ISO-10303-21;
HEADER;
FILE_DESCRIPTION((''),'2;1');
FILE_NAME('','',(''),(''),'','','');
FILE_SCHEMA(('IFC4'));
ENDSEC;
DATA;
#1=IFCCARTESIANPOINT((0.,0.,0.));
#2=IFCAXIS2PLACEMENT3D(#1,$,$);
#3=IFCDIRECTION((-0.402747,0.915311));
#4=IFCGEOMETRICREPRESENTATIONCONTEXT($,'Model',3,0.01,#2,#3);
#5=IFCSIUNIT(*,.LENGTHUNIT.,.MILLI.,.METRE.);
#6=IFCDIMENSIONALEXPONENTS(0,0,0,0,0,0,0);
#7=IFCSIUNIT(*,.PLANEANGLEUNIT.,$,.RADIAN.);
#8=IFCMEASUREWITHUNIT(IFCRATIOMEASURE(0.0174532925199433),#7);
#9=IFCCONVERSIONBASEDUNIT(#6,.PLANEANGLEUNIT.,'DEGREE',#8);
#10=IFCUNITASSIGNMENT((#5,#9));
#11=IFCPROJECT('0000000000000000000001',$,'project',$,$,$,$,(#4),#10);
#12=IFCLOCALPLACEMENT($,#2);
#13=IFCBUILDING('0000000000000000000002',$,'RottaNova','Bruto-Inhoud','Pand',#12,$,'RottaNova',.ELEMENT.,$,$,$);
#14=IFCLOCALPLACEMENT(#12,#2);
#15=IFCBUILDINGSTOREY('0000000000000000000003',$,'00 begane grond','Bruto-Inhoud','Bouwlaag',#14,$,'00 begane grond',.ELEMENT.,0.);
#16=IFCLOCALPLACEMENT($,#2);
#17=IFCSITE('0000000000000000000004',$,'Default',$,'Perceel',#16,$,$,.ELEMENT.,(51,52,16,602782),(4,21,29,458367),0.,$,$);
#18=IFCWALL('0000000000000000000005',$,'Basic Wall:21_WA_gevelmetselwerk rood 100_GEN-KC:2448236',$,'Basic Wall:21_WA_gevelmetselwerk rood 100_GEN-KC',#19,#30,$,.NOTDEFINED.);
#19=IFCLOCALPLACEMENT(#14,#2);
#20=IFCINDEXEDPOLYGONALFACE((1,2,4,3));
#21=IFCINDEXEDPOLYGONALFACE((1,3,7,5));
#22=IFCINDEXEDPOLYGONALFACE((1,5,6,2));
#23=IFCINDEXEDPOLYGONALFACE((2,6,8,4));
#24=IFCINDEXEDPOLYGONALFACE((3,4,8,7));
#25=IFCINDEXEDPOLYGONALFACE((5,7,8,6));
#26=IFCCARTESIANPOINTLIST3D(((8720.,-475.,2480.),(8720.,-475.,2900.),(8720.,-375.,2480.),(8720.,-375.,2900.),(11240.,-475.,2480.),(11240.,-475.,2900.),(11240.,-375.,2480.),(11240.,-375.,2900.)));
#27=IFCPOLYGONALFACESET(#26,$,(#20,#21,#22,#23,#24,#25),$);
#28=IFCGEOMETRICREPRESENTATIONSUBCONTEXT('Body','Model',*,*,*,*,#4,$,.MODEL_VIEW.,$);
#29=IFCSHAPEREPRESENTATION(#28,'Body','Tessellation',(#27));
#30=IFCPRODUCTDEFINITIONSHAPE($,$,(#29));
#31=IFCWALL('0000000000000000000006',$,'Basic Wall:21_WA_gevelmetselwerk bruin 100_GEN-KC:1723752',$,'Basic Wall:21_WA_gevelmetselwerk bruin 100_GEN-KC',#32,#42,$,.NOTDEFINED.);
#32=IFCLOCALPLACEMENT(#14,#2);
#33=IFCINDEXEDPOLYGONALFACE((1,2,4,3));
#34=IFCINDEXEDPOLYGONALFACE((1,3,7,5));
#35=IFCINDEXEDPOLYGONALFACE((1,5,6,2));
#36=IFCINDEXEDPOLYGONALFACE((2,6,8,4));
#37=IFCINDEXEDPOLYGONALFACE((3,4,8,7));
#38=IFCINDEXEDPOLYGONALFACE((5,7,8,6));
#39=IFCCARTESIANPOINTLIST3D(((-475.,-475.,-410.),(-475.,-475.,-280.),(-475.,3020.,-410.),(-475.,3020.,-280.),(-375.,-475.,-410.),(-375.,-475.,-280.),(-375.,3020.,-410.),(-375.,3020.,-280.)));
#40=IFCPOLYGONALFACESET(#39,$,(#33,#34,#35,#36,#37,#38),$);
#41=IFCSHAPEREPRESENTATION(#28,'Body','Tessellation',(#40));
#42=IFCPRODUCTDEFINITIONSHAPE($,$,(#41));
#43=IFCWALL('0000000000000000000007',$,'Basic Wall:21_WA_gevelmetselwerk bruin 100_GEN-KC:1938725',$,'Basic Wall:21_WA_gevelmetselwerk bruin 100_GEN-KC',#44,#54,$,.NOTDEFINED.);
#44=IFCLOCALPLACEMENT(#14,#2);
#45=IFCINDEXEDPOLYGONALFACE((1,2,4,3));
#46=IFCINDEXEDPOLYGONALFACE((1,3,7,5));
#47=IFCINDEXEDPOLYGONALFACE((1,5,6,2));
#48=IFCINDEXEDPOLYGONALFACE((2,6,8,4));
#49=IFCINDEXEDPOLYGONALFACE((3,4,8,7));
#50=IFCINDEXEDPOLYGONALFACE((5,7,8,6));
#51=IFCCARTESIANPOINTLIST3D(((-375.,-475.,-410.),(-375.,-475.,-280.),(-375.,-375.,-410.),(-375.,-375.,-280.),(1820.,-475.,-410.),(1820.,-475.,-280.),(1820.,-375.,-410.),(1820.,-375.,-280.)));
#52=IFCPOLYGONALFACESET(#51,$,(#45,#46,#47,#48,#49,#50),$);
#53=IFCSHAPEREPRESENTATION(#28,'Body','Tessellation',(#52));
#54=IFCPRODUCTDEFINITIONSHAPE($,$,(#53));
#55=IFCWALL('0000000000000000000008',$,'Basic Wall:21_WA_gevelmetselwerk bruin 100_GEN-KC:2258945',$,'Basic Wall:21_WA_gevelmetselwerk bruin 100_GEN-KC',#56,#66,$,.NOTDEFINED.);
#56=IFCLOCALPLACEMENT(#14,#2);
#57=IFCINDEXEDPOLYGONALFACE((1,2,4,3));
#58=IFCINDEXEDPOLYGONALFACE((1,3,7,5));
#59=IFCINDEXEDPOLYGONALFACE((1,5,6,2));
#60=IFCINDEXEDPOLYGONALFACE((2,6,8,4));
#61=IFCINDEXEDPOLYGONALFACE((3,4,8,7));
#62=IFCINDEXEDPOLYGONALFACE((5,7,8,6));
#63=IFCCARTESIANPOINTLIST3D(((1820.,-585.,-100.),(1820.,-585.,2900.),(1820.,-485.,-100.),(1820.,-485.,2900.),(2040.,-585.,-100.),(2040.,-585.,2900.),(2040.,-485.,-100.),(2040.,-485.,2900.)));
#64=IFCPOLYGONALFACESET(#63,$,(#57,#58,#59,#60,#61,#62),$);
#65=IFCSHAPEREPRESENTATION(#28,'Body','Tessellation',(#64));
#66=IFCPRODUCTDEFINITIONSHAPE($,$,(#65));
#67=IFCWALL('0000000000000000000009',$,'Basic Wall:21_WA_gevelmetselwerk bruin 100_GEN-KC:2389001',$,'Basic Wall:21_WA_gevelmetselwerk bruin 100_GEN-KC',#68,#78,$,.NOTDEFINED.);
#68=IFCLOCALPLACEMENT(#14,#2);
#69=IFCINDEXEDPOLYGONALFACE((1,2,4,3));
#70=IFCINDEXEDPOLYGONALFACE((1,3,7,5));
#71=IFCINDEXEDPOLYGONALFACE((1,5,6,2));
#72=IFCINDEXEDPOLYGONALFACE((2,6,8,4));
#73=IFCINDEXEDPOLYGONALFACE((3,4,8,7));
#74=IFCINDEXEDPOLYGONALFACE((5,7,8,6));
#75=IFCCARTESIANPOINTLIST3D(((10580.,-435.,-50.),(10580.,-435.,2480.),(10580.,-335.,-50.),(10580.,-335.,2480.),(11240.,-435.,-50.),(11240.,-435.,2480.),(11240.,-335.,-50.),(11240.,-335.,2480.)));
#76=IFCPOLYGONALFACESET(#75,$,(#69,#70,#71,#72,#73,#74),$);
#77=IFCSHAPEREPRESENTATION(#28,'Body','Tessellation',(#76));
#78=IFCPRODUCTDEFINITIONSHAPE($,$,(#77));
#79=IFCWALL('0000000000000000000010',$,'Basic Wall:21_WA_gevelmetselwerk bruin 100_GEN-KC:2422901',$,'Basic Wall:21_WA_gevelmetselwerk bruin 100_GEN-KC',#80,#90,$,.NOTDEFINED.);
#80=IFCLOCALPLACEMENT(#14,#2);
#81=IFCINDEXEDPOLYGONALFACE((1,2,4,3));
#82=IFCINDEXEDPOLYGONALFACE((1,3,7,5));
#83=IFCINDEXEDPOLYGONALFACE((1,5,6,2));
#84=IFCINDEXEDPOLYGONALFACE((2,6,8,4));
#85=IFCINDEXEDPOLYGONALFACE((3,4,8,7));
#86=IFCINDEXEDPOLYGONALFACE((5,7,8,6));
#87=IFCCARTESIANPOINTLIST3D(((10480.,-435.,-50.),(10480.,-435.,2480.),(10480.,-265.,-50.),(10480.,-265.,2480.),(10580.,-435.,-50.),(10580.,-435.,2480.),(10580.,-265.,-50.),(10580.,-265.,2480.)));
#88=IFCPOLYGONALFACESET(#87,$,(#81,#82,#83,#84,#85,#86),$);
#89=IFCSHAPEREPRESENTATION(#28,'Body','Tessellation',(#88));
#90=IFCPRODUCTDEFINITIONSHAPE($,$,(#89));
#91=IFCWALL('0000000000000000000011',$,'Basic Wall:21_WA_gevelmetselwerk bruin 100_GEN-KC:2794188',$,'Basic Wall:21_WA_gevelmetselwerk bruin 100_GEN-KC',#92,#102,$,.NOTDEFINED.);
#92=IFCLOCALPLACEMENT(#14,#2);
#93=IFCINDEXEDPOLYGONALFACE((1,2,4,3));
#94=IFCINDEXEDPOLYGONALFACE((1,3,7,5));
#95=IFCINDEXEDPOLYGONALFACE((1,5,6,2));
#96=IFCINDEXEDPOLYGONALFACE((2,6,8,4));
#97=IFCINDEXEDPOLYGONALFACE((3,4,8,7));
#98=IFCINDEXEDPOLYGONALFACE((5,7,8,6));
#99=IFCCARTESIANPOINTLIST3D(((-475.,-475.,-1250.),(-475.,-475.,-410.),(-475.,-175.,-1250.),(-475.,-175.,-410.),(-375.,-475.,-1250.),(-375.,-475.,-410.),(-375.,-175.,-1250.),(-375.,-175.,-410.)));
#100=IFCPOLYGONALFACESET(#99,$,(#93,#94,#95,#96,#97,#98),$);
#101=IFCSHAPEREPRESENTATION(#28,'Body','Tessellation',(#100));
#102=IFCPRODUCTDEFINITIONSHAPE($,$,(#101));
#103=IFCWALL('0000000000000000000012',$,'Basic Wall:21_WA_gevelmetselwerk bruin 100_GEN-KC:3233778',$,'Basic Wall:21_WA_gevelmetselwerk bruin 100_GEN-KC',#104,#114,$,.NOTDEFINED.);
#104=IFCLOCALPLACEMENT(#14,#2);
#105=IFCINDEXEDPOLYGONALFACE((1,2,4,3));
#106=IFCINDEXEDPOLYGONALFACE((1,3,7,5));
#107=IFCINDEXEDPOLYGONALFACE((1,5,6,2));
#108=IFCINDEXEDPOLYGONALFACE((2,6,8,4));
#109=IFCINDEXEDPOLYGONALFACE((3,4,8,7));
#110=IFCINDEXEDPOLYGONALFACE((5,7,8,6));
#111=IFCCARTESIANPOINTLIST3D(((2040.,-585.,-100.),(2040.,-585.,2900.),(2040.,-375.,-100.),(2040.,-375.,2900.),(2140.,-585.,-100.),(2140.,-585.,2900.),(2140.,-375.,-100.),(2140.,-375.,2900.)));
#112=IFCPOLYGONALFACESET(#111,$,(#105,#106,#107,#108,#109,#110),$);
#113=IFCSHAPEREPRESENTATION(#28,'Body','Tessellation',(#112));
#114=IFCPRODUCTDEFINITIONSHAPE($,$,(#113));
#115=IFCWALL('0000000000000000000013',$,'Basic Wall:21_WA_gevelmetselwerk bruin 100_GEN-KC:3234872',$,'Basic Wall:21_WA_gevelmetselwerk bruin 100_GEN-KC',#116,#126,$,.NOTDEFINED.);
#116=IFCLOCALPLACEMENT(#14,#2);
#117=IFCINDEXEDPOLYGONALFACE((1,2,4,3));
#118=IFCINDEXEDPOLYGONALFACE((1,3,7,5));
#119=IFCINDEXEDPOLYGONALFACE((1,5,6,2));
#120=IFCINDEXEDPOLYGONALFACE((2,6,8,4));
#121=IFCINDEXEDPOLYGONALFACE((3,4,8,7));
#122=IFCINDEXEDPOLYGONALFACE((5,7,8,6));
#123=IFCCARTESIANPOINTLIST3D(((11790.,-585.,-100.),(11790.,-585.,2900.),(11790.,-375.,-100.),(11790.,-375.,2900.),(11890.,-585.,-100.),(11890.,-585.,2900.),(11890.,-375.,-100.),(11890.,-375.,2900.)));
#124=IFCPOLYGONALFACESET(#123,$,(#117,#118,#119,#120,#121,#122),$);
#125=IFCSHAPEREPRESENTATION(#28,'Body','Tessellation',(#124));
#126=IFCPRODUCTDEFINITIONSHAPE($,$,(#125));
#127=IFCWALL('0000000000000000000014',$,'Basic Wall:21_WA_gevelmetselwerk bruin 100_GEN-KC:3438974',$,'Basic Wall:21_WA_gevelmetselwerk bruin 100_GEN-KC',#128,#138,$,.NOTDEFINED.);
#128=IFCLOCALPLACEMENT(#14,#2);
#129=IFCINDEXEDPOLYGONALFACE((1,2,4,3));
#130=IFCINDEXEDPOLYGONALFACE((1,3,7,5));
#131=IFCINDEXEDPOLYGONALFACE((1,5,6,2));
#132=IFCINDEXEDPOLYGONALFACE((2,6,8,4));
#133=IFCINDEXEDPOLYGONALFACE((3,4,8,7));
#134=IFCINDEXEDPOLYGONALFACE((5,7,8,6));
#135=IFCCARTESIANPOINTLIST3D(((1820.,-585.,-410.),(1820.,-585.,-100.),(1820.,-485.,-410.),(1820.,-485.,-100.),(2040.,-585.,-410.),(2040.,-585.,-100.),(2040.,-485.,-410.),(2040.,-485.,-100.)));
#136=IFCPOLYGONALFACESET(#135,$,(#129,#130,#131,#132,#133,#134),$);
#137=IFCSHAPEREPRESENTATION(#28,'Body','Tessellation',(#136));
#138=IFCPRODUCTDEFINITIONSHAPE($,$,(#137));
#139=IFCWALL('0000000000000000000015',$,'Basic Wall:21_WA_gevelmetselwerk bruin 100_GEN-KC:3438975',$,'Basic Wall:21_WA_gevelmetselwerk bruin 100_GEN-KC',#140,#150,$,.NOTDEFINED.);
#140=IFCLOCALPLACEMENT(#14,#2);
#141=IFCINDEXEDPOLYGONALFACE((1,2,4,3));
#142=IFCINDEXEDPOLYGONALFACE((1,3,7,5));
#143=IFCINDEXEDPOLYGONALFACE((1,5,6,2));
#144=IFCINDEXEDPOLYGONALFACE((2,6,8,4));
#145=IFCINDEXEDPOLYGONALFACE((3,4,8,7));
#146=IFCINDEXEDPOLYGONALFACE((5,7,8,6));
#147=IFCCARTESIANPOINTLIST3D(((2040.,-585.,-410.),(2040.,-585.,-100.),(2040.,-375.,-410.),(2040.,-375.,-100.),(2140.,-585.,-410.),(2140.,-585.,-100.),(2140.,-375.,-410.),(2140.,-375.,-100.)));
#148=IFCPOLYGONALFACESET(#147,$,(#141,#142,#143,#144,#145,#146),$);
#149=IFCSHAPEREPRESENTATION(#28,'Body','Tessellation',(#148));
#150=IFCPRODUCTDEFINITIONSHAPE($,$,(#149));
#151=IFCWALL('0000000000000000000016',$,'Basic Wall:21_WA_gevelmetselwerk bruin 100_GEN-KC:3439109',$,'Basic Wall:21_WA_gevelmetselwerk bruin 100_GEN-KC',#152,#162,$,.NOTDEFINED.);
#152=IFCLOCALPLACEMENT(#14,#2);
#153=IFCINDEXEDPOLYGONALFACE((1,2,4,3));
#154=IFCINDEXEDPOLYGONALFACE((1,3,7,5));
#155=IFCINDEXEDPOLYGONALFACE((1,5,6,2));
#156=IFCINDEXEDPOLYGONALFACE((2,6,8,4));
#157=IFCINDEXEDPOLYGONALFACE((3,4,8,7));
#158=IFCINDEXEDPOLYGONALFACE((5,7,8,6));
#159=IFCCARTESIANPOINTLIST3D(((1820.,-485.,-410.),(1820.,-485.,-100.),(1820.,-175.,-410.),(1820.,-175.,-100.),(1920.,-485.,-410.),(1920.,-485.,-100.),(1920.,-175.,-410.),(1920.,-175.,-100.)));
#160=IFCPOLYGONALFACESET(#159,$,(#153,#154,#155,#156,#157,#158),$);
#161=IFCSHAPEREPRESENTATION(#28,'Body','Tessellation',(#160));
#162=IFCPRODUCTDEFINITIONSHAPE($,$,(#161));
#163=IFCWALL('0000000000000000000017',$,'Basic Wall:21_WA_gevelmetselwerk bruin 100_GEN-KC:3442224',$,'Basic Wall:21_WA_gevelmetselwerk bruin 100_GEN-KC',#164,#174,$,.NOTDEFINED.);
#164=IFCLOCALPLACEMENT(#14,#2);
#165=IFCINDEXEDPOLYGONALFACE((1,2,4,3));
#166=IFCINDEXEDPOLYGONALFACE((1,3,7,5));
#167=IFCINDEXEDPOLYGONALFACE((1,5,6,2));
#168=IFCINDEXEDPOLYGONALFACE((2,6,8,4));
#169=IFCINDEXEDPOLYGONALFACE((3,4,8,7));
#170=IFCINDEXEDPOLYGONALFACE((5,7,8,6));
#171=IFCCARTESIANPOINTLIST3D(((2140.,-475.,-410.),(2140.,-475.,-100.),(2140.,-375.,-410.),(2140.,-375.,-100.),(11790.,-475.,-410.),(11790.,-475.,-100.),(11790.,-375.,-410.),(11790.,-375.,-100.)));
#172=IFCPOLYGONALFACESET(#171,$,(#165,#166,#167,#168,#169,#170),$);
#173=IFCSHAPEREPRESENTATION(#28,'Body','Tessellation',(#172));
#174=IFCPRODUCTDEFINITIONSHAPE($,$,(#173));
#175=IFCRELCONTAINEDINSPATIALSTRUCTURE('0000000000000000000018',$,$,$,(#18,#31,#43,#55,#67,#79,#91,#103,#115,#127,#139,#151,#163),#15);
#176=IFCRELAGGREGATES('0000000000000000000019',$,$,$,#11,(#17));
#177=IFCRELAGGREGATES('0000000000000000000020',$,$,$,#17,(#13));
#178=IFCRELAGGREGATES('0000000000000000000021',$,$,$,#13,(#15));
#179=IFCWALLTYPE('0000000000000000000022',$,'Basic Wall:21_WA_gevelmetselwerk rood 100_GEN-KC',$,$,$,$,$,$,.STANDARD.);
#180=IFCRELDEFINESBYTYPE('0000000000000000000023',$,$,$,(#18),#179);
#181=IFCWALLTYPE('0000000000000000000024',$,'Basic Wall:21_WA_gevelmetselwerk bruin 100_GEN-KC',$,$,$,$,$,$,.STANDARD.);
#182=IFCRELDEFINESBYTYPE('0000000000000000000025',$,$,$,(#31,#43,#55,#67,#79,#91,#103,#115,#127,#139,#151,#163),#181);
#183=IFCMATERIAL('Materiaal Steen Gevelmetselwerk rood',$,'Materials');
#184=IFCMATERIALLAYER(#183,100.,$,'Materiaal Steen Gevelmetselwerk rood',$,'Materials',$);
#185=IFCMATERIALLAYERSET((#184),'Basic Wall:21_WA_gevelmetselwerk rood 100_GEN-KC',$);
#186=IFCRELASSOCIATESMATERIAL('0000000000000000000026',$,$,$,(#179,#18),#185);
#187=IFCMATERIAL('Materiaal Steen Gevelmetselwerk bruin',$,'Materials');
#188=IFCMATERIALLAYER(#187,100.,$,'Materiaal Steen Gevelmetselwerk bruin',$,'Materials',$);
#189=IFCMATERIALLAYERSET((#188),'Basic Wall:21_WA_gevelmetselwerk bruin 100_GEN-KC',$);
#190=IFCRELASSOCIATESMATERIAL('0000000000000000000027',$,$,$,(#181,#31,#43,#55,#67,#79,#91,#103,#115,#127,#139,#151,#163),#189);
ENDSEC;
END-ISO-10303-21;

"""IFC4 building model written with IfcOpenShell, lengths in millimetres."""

from ifc_helpers import new_model, entity, si_unit, converted_unit, direction, frame, frame_2d, origin, place, context, subcontext, project, spatial, rectangle, extrude, material, layer, layer_set, type_object, element, save


model = new_model("IFC4")

# Units and contexts
model_context = context("Model", 3, precision=0.01, world=origin(), true_north=direction((-0.402747, 0.915311)))
body_context = subcontext(model_context, "Body", "Model", "MODEL_VIEW")
ifc_project = project(units=[si_unit("LENGTHUNIT", "METRE", prefix="MILLI"), converted_unit("PLANEANGLEUNIT", "DEGREE", entity("IfcRatioMeasure", 0.0174532925199433), si_unit("PLANEANGLEUNIT", "RADIAN"), dimensions=[0, 0, 0, 0, 0, 0, 0])], contexts=[model_context])

# Site, building, storey
site_placement = place(None, origin())
site = spatial("IfcSite", under=ifc_project, at=site_placement, Name="Default", ObjectType="Perceel", CompositionType="ELEMENT", RefLatitude=(51, 52, 16, 602782), RefLongitude=(4, 21, 29, 458367), RefElevation=0.0)
building_placement = place(None, origin())
building = spatial("IfcBuilding", under=site, at=building_placement, Name="RottaNova", Description="Bruto-Inhoud", ObjectType="Pand", LongName="RottaNova", CompositionType="ELEMENT")
storey_placement = place(building_placement, origin())
storey = spatial("IfcBuildingStorey", under=building, at=storey_placement, Name="00 begane grond", Description="Bruto-Inhoud", ObjectType="Bouwlaag", LongName="00 begane grond", CompositionType="ELEMENT", Elevation=0.0)

# Walls
ifc_material_1 = material(Name="Materiaal Steen Gevelmetselwerk rood", Category="Materials")
ifc_layer_1 = layer(ifc_material_1, 100.0, Name="Materiaal Steen Gevelmetselwerk rood", Category="Materials")
ifc_layer_set_1 = layer_set([ifc_layer_1], Name="Basic Wall:21_WA_gevelmetselwerk rood 100_GEN-KC")
wall_type_1 = type_object("IfcWallType", Name="Basic Wall:21_WA_gevelmetselwerk rood 100_GEN-KC", PredefinedType="STANDARD", material=ifc_layer_set_1)
wall_1_placement = place(storey_placement, frame((8720.0, -425.0, 2480.0)))
element("IfcWall", 1, at=wall_1_placement, inside=storey, type_object=wall_type_1, material=ifc_layer_set_1, Name="Basic Wall:21_WA_gevelmetselwerk rood 100_GEN-KC:2448236", ObjectType="Basic Wall:21_WA_gevelmetselwerk rood 100_GEN-KC", PredefinedType="NOTDEFINED", context=body_context, shape_type="SweptSolid", body=[
    extrude(rectangle(XDim=2520.0, YDim=100.0, at=frame_2d((1260.0, 0.0), x_axis=(-1.0, 0.0))), origin(), (0.0, 0.0, 1.0), 420.0),
])
ifc_material_2 = material(Name="Materiaal Steen Gevelmetselwerk bruin", Category="Materials")
ifc_layer_2 = layer(ifc_material_2, 100.0, Name="Materiaal Steen Gevelmetselwerk bruin", Category="Materials")
ifc_layer_set_2 = layer_set([ifc_layer_2], Name="Basic Wall:21_WA_gevelmetselwerk bruin 100_GEN-KC")
wall_type_2 = type_object("IfcWallType", Name="Basic Wall:21_WA_gevelmetselwerk bruin 100_GEN-KC", PredefinedType="STANDARD", material=ifc_layer_set_2)
wall_2_placement = place(storey_placement, frame((-425.0, -475.0, -410.0), z_axis=(0.0, 0.0, 1.0), x_axis=(0.0, 1.0, 0.0)))
element("IfcWall", 2, at=wall_2_placement, inside=storey, type_object=wall_type_2, material=ifc_layer_set_2, Name="Basic Wall:21_WA_gevelmetselwerk bruin 100_GEN-KC:1723752", ObjectType="Basic Wall:21_WA_gevelmetselwerk bruin 100_GEN-KC", PredefinedType="NOTDEFINED", context=body_context, shape_type="SweptSolid", body=[
    extrude(rectangle(XDim=3495.0, YDim=100.0, at=frame_2d((1747.5, 0.0), x_axis=(-1.0, 0.0))), origin(), (0.0, 0.0, 1.0), 130.0),
])
wall_3_placement = place(storey_placement, frame((1820.0, -425.0, -410.0), z_axis=(0.0, 0.0, 1.0), x_axis=(-1.0, 0.0, 0.0)))
element("IfcWall", 3, at=wall_3_placement, inside=storey, type_object=wall_type_2, material=ifc_layer_set_2, Name="Basic Wall:21_WA_gevelmetselwerk bruin 100_GEN-KC:1938725", ObjectType="Basic Wall:21_WA_gevelmetselwerk bruin 100_GEN-KC", PredefinedType="NOTDEFINED", context=body_context, shape_type="SweptSolid", body=[
    extrude(rectangle(XDim=2195.0, YDim=100.0, at=frame_2d((1097.5, 0.0), x_axis=(-1.0, 0.0))), origin(), (0.0, 0.0, 1.0), 130.0),
])
wall_4_placement = place(storey_placement, frame((1820.0, -535.0, -100.0)))
element("IfcWall", 4, at=wall_4_placement, inside=storey, type_object=wall_type_2, material=ifc_layer_set_2, Name="Basic Wall:21_WA_gevelmetselwerk bruin 100_GEN-KC:2258945", ObjectType="Basic Wall:21_WA_gevelmetselwerk bruin 100_GEN-KC", PredefinedType="NOTDEFINED", context=body_context, shape_type="SweptSolid", body=[
    extrude(rectangle(XDim=220.0, YDim=100.0, at=frame_2d((110.0, 0.0), x_axis=(-1.0, 0.0))), origin(), (0.0, 0.0, 1.0), 3000.0),
])
wall_5_placement = place(storey_placement, frame((11240.0, -385.0, -50.0), z_axis=(0.0, 0.0, 1.0), x_axis=(-1.0, 0.0, 0.0)))
element("IfcWall", 5, at=wall_5_placement, inside=storey, type_object=wall_type_2, material=ifc_layer_set_2, Name="Basic Wall:21_WA_gevelmetselwerk bruin 100_GEN-KC:2389001", ObjectType="Basic Wall:21_WA_gevelmetselwerk bruin 100_GEN-KC", PredefinedType="NOTDEFINED", context=body_context, shape_type="SweptSolid", body=[
    extrude(rectangle(XDim=660.0, YDim=100.0, at=frame_2d((330.0, 0.0), x_axis=(-1.0, 0.0))), origin(), (0.0, 0.0, 1.0), 2530.0),
])
wall_6_placement = place(storey_placement, frame((10530.0, -265.0, -50.0), z_axis=(0.0, 0.0, 1.0), x_axis=(0.0, -1.0, 0.0)))
element("IfcWall", 6, at=wall_6_placement, inside=storey, type_object=wall_type_2, material=ifc_layer_set_2, Name="Basic Wall:21_WA_gevelmetselwerk bruin 100_GEN-KC:2422901", ObjectType="Basic Wall:21_WA_gevelmetselwerk bruin 100_GEN-KC", PredefinedType="NOTDEFINED", context=body_context, shape_type="SweptSolid", body=[
    extrude(rectangle(XDim=170.0, YDim=100.0, at=frame_2d((85.0, 0.0), x_axis=(-1.0, 0.0))), origin(), (0.0, 0.0, 1.0), 2530.0),
])
wall_7_placement = place(storey_placement, frame((-425.0, -475.0, -1250.0), z_axis=(0.0, 0.0, 1.0), x_axis=(0.0, 1.0, 0.0)))
element("IfcWall", 7, at=wall_7_placement, inside=storey, type_object=wall_type_2, material=ifc_layer_set_2, Name="Basic Wall:21_WA_gevelmetselwerk bruin 100_GEN-KC:2794188", ObjectType="Basic Wall:21_WA_gevelmetselwerk bruin 100_GEN-KC", PredefinedType="NOTDEFINED", context=body_context, shape_type="SweptSolid", body=[
    extrude(rectangle(XDim=300.0, YDim=100.0, at=frame_2d((150.0, 0.0), x_axis=(-1.0, 0.0))), origin(), (0.0, 0.0, 1.0), 840.0),
])
wall_8_placement = place(storey_placement, frame((2090.0, -585.0, -100.0), z_axis=(0.0, 0.0, 1.0), x_axis=(0.0, 1.0, 0.0)))
element("IfcWall", 8, at=wall_8_placement, inside=storey, type_object=wall_type_2, material=ifc_layer_set_2, Name="Basic Wall:21_WA_gevelmetselwerk bruin 100_GEN-KC:3233778", ObjectType="Basic Wall:21_WA_gevelmetselwerk bruin 100_GEN-KC", PredefinedType="NOTDEFINED", context=body_context, shape_type="SweptSolid", body=[
    extrude(rectangle(XDim=210.0, YDim=100.0, at=frame_2d((105.0, 0.0), x_axis=(-1.0, 0.0))), origin(), (0.0, 0.0, 1.0), 3000.0),
])
wall_9_placement = place(storey_placement, frame((11840.0, -585.0, -100.0), z_axis=(0.0, 0.0, 1.0), x_axis=(0.0, 1.0, 0.0)))
element("IfcWall", 9, at=wall_9_placement, inside=storey, type_object=wall_type_2, material=ifc_layer_set_2, Name="Basic Wall:21_WA_gevelmetselwerk bruin 100_GEN-KC:3234872", ObjectType="Basic Wall:21_WA_gevelmetselwerk bruin 100_GEN-KC", PredefinedType="NOTDEFINED", context=body_context, shape_type="SweptSolid", body=[
    extrude(rectangle(XDim=210.0, YDim=100.0, at=frame_2d((105.0, 0.0), x_axis=(-1.0, 0.0))), origin(), (0.0, 0.0, 1.0), 3000.0),
])
wall_10_placement = place(storey_placement, frame((1820.0, -535.0, -410.0)))
element("IfcWall", 10, at=wall_10_placement, inside=storey, type_object=wall_type_2, material=ifc_layer_set_2, Name="Basic Wall:21_WA_gevelmetselwerk bruin 100_GEN-KC:3438974", ObjectType="Basic Wall:21_WA_gevelmetselwerk bruin 100_GEN-KC", PredefinedType="NOTDEFINED", context=body_context, shape_type="SweptSolid", body=[
    extrude(rectangle(XDim=220.0, YDim=100.0, at=frame_2d((110.0, 0.0), x_axis=(-1.0, 0.0))), origin(), (0.0, 0.0, 1.0), 310.0),
])
wall_11_placement = place(storey_placement, frame((2090.0, -585.0, -410.0), z_axis=(0.0, 0.0, 1.0), x_axis=(0.0, 1.0, 0.0)))
element("IfcWall", 11, at=wall_11_placement, inside=storey, type_object=wall_type_2, material=ifc_layer_set_2, Name="Basic Wall:21_WA_gevelmetselwerk bruin 100_GEN-KC:3438975", ObjectType="Basic Wall:21_WA_gevelmetselwerk bruin 100_GEN-KC", PredefinedType="NOTDEFINED", context=body_context, shape_type="SweptSolid", body=[
    extrude(rectangle(XDim=210.0, YDim=100.0, at=frame_2d((105.0, 0.0), x_axis=(-1.0, 0.0))), origin(), (0.0, 0.0, 1.0), 310.0),
])
wall_12_placement = place(storey_placement, frame((1870.0, -175.0, -410.0), z_axis=(0.0, 0.0, 1.0), x_axis=(0.0, -1.0, 0.0)))
element("IfcWall", 12, at=wall_12_placement, inside=storey, type_object=wall_type_2, material=ifc_layer_set_2, Name="Basic Wall:21_WA_gevelmetselwerk bruin 100_GEN-KC:3439109", ObjectType="Basic Wall:21_WA_gevelmetselwerk bruin 100_GEN-KC", PredefinedType="NOTDEFINED", context=body_context, shape_type="SweptSolid", body=[
    extrude(rectangle(XDim=310.0, YDim=100.0, at=frame_2d((155.0, 0.0), x_axis=(-1.0, 0.0))), origin(), (0.0, 0.0, 1.0), 310.0),
])
wall_13_placement = place(storey_placement, frame((11790.0, -425.0, -410.0), z_axis=(0.0, 0.0, 1.0), x_axis=(-1.0, 0.0, 0.0)))
element("IfcWall", 13, at=wall_13_placement, inside=storey, type_object=wall_type_2, material=ifc_layer_set_2, Name="Basic Wall:21_WA_gevelmetselwerk bruin 100_GEN-KC:3442224", ObjectType="Basic Wall:21_WA_gevelmetselwerk bruin 100_GEN-KC", PredefinedType="NOTDEFINED", context=body_context, shape_type="SweptSolid", body=[
    extrude(rectangle(XDim=9650.0, YDim=100.0, at=frame_2d((4825.0, 0.0), x_axis=(-1.0, 0.0))), origin(), (0.0, 0.0, 1.0), 310.0),
])

save(model, "model.ifc")
